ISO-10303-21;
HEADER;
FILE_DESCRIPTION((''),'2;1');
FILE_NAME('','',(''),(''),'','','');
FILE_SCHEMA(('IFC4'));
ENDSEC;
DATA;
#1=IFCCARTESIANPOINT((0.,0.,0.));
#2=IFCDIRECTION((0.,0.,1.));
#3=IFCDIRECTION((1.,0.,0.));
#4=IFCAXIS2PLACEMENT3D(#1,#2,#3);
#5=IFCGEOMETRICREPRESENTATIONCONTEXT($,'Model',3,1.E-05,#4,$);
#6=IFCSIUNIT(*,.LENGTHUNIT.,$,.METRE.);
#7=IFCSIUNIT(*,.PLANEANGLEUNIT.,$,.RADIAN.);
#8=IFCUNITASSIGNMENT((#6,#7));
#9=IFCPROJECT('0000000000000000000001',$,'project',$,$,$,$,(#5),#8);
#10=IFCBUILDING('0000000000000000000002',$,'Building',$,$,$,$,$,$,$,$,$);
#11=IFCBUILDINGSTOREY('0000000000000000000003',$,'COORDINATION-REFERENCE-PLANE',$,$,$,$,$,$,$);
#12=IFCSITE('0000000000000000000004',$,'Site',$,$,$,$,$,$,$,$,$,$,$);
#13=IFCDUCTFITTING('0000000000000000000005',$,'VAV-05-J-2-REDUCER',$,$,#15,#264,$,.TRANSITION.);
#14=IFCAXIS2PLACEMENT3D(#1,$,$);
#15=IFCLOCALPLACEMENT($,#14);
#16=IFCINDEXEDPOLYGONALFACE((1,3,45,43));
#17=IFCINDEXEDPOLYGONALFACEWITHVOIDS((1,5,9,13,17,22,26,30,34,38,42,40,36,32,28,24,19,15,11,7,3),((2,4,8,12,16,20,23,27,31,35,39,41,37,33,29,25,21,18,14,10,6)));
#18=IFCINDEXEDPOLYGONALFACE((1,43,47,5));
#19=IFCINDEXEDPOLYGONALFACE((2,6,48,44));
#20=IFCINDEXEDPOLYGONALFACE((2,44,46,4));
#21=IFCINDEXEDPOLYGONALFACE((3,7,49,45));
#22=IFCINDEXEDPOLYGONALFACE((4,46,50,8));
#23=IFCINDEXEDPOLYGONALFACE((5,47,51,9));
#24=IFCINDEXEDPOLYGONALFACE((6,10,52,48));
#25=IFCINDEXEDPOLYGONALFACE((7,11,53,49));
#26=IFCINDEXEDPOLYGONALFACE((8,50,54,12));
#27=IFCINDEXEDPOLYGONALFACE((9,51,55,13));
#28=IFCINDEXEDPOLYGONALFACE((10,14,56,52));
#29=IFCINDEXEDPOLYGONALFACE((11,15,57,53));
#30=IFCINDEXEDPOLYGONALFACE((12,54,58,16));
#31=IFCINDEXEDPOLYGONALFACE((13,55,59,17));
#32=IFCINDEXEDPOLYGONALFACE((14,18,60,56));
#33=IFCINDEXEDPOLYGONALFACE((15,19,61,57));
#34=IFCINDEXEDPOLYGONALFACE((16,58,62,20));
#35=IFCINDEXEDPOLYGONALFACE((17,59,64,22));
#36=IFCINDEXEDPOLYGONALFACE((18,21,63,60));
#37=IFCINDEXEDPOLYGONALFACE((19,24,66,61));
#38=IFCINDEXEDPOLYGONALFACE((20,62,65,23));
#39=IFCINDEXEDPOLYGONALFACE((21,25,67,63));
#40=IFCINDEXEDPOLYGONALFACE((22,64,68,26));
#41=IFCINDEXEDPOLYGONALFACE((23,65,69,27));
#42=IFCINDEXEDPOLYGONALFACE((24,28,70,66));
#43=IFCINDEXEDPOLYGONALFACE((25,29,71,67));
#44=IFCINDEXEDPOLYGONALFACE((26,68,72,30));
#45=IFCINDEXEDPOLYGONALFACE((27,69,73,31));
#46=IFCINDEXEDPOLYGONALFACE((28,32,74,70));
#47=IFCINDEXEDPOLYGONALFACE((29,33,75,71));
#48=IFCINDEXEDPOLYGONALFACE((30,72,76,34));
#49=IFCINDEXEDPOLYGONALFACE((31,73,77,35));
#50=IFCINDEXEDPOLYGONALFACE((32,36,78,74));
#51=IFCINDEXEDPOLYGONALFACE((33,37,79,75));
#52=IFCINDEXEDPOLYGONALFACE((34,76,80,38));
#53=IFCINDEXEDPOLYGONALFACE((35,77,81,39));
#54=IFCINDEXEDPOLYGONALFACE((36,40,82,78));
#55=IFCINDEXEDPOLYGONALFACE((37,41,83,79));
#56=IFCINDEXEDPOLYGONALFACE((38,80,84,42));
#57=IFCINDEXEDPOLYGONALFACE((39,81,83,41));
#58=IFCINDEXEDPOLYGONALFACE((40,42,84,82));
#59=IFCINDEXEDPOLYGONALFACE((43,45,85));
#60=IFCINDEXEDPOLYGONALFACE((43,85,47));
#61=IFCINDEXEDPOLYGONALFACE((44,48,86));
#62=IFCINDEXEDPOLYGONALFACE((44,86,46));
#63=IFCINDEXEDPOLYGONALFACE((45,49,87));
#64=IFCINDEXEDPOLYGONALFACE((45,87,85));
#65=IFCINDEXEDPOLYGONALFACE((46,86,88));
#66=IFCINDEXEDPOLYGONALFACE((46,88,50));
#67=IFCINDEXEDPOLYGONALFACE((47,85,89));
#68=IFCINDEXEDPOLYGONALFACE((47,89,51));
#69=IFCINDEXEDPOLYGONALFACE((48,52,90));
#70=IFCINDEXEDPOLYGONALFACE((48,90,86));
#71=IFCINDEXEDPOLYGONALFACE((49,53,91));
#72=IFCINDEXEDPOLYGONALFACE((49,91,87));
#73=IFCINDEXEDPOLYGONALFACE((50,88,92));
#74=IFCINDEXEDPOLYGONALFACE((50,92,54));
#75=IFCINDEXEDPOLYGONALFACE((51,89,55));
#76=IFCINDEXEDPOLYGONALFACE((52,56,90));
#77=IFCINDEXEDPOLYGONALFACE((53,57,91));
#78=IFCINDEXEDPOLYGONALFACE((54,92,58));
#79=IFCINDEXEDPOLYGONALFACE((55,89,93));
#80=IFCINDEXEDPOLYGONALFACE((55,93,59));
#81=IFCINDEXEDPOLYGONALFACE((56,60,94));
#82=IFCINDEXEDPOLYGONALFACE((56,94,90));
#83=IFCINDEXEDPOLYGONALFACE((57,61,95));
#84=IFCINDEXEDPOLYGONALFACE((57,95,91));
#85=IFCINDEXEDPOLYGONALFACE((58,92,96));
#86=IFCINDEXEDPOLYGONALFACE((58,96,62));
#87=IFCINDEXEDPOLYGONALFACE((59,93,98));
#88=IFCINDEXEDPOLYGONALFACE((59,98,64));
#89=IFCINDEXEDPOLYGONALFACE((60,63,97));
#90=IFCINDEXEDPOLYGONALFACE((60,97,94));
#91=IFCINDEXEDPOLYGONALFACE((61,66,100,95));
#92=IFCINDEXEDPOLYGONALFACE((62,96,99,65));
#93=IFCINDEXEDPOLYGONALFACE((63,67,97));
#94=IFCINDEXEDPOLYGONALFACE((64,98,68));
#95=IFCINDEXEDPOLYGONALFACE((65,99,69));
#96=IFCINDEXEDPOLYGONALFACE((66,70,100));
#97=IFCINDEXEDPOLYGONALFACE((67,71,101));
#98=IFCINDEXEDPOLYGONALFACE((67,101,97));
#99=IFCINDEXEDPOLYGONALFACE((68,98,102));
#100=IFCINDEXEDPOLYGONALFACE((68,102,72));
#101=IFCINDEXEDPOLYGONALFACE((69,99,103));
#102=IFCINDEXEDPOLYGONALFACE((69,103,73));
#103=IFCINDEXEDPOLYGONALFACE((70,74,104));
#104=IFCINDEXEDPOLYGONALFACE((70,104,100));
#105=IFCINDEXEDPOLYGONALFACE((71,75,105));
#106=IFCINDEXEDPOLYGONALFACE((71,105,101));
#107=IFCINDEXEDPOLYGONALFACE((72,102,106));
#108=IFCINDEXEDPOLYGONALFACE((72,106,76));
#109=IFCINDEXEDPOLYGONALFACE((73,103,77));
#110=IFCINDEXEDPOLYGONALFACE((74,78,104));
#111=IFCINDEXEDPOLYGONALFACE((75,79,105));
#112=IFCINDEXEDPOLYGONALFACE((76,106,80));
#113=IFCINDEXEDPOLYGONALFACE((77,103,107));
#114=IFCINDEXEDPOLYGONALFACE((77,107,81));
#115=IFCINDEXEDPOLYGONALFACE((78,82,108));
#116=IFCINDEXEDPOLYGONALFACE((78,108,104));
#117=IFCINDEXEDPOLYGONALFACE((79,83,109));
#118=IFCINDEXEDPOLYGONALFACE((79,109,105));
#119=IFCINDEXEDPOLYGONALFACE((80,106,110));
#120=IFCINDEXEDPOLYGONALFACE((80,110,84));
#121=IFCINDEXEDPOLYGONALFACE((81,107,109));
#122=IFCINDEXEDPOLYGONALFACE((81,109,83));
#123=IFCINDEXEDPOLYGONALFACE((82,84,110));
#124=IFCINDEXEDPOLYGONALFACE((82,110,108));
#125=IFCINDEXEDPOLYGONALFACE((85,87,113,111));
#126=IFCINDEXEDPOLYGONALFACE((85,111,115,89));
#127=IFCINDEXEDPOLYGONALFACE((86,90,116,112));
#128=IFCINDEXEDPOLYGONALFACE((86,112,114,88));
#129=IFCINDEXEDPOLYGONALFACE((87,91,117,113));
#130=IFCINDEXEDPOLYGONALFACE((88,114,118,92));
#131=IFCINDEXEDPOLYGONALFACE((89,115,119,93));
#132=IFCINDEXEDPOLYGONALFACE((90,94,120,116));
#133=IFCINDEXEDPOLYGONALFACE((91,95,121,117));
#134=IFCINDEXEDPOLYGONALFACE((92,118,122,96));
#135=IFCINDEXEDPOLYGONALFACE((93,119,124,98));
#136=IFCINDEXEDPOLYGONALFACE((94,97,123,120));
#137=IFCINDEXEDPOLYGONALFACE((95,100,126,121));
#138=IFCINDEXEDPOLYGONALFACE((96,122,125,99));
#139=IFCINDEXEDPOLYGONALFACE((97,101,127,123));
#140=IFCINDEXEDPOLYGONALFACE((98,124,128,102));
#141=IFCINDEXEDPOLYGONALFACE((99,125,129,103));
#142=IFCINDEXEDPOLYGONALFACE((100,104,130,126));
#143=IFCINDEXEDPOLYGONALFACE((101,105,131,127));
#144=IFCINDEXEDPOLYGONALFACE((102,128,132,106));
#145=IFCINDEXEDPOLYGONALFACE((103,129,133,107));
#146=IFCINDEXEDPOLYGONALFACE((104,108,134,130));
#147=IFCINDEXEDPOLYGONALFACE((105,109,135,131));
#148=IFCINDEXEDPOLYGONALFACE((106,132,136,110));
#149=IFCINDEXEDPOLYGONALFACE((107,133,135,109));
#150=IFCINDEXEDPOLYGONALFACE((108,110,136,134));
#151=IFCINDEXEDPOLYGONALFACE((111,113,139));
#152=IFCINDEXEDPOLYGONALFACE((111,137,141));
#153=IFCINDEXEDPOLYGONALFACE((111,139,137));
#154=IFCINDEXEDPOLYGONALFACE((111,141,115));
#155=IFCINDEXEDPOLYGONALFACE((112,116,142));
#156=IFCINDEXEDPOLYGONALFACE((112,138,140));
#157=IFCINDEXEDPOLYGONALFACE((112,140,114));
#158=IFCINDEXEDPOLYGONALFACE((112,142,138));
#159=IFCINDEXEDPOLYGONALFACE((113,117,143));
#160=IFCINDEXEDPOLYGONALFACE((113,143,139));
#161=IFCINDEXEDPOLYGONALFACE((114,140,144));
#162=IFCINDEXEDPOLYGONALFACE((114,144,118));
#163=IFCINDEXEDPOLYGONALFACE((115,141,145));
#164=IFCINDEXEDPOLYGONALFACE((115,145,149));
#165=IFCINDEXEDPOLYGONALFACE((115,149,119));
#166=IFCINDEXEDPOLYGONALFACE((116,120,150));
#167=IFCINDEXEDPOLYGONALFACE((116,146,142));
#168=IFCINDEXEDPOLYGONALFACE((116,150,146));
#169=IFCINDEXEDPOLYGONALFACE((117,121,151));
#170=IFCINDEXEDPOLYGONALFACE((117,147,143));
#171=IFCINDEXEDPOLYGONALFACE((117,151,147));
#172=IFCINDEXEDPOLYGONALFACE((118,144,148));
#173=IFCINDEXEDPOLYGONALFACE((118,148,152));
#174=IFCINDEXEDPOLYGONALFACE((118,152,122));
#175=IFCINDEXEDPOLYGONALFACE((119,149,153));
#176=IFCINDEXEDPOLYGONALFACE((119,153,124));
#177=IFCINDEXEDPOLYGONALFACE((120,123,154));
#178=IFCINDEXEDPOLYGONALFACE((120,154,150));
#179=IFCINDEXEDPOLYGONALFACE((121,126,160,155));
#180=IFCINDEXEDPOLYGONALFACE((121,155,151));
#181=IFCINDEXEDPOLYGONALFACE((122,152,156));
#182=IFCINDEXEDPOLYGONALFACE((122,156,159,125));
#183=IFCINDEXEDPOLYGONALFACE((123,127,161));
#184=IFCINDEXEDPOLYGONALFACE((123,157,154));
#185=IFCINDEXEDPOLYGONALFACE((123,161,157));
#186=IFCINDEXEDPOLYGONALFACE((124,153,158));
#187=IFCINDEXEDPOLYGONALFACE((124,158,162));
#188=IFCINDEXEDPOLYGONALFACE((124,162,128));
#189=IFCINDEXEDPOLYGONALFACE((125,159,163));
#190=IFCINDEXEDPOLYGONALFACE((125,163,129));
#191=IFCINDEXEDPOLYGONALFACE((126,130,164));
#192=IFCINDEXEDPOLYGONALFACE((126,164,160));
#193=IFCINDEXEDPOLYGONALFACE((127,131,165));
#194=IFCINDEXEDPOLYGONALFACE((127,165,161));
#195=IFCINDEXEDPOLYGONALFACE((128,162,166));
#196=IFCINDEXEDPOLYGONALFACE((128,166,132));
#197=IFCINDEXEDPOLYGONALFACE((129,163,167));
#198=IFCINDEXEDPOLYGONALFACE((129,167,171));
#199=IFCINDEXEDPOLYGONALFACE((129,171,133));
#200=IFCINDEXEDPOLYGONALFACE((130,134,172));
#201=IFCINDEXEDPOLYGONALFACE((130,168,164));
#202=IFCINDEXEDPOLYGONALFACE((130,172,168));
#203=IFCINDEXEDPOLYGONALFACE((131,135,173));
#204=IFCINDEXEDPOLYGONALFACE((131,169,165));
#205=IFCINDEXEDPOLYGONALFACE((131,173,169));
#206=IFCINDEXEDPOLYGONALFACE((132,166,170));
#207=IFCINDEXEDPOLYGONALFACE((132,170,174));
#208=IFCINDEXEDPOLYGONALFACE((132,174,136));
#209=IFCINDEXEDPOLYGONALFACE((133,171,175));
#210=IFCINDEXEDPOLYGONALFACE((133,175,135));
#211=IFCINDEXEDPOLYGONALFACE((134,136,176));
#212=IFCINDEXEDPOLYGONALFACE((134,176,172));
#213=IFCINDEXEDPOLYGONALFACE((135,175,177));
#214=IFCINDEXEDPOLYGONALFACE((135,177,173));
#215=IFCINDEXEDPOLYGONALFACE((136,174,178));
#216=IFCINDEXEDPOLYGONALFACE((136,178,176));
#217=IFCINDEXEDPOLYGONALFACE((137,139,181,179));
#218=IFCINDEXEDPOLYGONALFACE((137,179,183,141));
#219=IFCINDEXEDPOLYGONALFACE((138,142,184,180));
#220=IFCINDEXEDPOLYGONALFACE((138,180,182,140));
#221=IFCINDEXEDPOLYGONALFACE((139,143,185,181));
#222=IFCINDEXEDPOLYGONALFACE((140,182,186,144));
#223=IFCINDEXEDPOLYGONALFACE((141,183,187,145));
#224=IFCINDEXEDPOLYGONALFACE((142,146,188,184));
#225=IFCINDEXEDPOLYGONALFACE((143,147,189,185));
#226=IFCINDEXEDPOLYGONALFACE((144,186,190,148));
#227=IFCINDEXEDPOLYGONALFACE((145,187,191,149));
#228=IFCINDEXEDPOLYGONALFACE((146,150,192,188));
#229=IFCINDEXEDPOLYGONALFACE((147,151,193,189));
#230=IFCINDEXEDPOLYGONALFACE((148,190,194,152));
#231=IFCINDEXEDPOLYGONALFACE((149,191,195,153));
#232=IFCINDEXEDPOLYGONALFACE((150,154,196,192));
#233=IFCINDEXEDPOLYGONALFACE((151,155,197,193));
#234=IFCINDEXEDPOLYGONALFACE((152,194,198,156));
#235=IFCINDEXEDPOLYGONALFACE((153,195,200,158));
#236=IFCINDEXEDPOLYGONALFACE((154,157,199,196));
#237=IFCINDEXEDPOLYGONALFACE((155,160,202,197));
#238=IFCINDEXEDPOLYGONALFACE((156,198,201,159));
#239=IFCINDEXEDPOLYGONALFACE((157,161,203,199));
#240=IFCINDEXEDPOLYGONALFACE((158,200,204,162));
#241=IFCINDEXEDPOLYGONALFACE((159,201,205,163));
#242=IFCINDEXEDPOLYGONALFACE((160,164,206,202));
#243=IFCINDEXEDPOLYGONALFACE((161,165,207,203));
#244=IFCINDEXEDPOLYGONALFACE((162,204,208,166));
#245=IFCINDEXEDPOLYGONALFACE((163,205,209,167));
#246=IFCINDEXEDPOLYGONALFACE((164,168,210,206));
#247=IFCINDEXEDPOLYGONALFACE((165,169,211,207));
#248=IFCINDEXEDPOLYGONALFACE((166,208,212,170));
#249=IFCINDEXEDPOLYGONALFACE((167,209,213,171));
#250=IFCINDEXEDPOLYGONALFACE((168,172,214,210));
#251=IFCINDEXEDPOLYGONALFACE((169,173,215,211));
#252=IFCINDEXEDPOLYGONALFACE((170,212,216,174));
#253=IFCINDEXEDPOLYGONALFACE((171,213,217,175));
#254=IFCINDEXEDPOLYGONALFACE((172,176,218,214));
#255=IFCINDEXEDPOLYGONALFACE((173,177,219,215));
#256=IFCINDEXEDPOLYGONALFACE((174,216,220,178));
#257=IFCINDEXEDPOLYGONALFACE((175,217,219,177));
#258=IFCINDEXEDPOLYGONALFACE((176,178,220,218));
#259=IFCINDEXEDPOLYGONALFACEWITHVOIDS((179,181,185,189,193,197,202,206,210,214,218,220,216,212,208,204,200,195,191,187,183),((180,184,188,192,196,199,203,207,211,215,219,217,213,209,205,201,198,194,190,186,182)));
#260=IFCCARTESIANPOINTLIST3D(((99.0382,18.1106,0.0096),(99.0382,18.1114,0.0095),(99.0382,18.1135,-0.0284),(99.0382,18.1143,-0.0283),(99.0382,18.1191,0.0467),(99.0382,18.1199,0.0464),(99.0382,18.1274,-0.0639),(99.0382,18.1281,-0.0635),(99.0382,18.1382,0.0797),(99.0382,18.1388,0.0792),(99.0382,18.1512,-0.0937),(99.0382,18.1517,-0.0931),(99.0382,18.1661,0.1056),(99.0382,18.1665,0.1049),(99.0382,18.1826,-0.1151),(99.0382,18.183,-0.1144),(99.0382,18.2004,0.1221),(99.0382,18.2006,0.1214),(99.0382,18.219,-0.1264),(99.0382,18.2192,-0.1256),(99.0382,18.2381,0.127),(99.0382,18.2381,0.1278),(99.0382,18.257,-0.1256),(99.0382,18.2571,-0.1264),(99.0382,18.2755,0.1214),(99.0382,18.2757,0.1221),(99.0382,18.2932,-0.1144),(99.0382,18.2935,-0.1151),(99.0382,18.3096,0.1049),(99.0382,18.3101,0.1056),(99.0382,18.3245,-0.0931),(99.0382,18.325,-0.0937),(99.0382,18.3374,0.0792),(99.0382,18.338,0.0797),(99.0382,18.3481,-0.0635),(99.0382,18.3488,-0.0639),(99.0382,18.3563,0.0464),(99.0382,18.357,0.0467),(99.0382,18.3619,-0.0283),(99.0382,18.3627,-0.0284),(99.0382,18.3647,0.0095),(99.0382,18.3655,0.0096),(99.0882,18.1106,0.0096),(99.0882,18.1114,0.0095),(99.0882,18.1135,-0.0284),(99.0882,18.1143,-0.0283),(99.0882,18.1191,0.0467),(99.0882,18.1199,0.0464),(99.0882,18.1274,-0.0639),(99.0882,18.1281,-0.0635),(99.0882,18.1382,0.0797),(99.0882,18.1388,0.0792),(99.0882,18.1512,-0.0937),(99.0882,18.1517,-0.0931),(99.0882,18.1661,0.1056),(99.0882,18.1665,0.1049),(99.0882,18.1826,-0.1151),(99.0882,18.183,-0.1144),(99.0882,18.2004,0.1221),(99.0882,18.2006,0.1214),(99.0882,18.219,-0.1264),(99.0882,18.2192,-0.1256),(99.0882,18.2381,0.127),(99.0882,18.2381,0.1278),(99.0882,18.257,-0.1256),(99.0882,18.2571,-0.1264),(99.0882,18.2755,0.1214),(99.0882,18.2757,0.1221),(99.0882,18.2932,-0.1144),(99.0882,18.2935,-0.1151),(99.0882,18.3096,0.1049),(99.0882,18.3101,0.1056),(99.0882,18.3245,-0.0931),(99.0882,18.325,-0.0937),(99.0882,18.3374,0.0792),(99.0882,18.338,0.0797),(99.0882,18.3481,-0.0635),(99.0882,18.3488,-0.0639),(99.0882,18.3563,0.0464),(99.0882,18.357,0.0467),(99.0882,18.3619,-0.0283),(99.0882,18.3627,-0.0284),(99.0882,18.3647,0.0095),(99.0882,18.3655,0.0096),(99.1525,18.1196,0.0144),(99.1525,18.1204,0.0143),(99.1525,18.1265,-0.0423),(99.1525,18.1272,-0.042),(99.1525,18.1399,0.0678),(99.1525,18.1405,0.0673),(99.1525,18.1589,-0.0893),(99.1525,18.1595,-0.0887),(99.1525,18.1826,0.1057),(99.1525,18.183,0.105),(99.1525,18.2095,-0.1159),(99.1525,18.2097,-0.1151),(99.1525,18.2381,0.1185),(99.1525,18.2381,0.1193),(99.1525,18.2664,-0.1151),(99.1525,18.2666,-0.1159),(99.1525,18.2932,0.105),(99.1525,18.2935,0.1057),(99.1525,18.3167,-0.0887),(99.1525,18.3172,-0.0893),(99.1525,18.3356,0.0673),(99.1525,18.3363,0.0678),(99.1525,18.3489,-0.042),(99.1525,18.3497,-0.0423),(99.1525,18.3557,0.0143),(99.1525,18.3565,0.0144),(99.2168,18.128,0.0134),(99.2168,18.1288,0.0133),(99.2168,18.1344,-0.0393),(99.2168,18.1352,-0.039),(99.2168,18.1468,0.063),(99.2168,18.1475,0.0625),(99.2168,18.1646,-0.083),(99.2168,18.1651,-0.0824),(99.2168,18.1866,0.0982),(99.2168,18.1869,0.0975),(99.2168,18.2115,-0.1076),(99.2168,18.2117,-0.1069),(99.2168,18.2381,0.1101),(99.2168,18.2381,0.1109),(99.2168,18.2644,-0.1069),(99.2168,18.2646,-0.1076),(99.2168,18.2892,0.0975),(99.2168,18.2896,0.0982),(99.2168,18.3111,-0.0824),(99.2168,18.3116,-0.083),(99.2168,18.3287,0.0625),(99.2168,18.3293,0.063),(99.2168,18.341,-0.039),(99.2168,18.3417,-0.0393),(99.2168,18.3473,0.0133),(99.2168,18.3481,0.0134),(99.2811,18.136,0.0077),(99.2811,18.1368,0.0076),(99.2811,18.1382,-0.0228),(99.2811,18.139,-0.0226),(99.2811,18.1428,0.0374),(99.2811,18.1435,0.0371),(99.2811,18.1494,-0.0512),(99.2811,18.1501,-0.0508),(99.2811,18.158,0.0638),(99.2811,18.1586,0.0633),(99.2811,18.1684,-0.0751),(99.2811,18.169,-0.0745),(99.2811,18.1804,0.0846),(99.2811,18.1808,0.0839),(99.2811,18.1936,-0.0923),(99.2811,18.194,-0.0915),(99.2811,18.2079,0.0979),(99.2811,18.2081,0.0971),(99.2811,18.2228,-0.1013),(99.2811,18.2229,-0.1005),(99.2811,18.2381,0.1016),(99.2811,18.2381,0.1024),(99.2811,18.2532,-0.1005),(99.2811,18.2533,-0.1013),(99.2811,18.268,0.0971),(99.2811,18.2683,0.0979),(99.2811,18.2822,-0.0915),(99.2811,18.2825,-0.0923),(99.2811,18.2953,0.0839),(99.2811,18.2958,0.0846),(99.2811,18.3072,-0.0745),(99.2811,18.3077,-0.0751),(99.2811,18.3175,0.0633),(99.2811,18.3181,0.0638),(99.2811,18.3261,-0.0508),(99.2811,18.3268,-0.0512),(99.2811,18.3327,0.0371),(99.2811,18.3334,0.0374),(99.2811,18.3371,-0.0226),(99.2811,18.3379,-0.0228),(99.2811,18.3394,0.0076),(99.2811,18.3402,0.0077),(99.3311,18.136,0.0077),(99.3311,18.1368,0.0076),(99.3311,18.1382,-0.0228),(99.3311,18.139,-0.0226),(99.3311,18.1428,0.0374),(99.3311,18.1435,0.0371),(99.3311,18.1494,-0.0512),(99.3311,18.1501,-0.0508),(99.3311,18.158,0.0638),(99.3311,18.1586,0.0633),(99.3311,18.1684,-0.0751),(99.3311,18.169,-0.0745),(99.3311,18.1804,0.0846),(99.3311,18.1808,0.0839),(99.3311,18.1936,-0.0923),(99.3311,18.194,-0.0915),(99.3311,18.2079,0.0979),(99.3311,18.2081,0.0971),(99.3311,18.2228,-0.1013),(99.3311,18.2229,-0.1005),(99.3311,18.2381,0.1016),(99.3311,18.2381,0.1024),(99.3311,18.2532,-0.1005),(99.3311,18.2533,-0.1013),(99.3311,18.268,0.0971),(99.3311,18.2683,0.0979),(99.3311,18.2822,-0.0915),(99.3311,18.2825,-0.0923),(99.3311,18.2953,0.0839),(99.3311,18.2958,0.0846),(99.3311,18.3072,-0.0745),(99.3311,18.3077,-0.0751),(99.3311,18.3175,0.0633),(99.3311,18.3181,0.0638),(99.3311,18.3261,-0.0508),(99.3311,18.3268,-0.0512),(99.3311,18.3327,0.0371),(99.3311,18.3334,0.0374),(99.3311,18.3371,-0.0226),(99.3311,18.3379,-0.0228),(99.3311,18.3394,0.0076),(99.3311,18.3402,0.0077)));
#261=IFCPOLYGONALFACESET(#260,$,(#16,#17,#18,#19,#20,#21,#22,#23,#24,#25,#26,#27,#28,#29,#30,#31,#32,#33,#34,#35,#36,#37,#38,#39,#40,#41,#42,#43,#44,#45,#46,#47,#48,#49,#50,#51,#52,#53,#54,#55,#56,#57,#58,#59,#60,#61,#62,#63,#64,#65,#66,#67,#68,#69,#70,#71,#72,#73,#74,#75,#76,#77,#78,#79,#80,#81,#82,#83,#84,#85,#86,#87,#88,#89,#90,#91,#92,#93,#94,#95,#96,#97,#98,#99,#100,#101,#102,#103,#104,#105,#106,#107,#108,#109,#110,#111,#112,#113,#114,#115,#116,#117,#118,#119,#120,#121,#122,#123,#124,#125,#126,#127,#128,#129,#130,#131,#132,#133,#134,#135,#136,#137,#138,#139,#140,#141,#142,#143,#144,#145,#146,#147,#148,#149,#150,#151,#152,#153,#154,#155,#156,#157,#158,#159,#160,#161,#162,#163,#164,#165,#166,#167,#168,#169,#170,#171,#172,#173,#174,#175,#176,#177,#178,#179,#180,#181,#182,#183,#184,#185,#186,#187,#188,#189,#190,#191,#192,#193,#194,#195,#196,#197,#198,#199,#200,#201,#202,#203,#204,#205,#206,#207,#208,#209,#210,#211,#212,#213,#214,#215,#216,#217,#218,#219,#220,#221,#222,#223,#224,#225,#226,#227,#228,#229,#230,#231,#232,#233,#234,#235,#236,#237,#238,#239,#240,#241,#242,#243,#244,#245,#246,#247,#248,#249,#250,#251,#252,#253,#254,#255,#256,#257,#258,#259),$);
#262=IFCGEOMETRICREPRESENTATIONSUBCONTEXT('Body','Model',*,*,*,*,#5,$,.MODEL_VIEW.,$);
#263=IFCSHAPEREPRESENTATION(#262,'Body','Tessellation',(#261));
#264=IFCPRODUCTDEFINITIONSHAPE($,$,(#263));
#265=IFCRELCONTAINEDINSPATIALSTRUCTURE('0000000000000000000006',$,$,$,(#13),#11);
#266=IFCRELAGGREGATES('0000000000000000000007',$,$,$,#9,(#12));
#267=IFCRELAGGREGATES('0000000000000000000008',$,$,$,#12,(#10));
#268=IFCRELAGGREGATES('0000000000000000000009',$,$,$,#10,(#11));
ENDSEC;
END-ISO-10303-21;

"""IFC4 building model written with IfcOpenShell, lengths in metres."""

from ifc_helpers import new_model, entity, si_unit, frame, origin_with_axes, place, context, subcontext, project, spatial, element, save


model = new_model("IFC4")

# Units and contexts
model_context_1 = context("Model", 3, precision=1e-05, world=origin_with_axes())
body_context_1 = subcontext(model_context_1, "Body", "Model", "MODEL_VIEW")
ifc_project = project(units=[si_unit("LENGTHUNIT", "METRE"), si_unit("PLANEANGLEUNIT", "RADIAN")], contexts=[model_context_1])

# Site, building, storey
site = spatial("IfcSite", under=ifc_project, Name="Site")
building = spatial("IfcBuilding", under=site, Name="Building")
storey = spatial("IfcBuildingStorey", under=building, Name="COORDINATION-REFERENCE-PLANE")

# Duct fitting
for number, where, z_axis, x_axis, name in (
    (1, (99.0382, 18.2381, 0.0), (0.0, 1.0, 0.0), (0.0, 0.0, 1.0), "VAV-05-J-2-REDUCER"),
):
    element("IfcDuctFitting", number, at=place(None, frame(where, z_axis=z_axis, x_axis=x_axis)), inside=storey, Name=name, PredefinedType="TRANSITION", context=body_context_1, shape_type="SweptSolid", body=[
        entity("IfcRevolvedAreaSolid", entity("IfcArbitraryClosedProfileDef", "AREA", None, entity("IfcPolyline", [entity("IfcCartesianPoint", [0.1278, 0.0]), entity("IfcCartesianPoint", [0.1278, 0.05]), entity("IfcCartesianPoint", [0.1024, 0.2429]), entity("IfcCartesianPoint", [0.1024, 0.2929]), entity("IfcCartesianPoint", [0.1016, 0.2929]), entity("IfcCartesianPoint", [0.1016, 0.2429]), entity("IfcCartesianPoint", [0.127, 0.05]), entity("IfcCartesianPoint", [0.127, 0.0]), entity("IfcCartesianPoint", [0.1278, 0.0])])), entity("IfcAxis2Placement3D", entity("IfcCartesianPoint", [0.0, 0.0, 0.0])), entity("IfcAxis1Placement", entity("IfcCartesianPoint", [0.0, 0.0, 0.0]), entity("IfcDirection", [0.0, 1.0, 0.0])), 6.283185),
    ])

save(model, "model.ifc")
